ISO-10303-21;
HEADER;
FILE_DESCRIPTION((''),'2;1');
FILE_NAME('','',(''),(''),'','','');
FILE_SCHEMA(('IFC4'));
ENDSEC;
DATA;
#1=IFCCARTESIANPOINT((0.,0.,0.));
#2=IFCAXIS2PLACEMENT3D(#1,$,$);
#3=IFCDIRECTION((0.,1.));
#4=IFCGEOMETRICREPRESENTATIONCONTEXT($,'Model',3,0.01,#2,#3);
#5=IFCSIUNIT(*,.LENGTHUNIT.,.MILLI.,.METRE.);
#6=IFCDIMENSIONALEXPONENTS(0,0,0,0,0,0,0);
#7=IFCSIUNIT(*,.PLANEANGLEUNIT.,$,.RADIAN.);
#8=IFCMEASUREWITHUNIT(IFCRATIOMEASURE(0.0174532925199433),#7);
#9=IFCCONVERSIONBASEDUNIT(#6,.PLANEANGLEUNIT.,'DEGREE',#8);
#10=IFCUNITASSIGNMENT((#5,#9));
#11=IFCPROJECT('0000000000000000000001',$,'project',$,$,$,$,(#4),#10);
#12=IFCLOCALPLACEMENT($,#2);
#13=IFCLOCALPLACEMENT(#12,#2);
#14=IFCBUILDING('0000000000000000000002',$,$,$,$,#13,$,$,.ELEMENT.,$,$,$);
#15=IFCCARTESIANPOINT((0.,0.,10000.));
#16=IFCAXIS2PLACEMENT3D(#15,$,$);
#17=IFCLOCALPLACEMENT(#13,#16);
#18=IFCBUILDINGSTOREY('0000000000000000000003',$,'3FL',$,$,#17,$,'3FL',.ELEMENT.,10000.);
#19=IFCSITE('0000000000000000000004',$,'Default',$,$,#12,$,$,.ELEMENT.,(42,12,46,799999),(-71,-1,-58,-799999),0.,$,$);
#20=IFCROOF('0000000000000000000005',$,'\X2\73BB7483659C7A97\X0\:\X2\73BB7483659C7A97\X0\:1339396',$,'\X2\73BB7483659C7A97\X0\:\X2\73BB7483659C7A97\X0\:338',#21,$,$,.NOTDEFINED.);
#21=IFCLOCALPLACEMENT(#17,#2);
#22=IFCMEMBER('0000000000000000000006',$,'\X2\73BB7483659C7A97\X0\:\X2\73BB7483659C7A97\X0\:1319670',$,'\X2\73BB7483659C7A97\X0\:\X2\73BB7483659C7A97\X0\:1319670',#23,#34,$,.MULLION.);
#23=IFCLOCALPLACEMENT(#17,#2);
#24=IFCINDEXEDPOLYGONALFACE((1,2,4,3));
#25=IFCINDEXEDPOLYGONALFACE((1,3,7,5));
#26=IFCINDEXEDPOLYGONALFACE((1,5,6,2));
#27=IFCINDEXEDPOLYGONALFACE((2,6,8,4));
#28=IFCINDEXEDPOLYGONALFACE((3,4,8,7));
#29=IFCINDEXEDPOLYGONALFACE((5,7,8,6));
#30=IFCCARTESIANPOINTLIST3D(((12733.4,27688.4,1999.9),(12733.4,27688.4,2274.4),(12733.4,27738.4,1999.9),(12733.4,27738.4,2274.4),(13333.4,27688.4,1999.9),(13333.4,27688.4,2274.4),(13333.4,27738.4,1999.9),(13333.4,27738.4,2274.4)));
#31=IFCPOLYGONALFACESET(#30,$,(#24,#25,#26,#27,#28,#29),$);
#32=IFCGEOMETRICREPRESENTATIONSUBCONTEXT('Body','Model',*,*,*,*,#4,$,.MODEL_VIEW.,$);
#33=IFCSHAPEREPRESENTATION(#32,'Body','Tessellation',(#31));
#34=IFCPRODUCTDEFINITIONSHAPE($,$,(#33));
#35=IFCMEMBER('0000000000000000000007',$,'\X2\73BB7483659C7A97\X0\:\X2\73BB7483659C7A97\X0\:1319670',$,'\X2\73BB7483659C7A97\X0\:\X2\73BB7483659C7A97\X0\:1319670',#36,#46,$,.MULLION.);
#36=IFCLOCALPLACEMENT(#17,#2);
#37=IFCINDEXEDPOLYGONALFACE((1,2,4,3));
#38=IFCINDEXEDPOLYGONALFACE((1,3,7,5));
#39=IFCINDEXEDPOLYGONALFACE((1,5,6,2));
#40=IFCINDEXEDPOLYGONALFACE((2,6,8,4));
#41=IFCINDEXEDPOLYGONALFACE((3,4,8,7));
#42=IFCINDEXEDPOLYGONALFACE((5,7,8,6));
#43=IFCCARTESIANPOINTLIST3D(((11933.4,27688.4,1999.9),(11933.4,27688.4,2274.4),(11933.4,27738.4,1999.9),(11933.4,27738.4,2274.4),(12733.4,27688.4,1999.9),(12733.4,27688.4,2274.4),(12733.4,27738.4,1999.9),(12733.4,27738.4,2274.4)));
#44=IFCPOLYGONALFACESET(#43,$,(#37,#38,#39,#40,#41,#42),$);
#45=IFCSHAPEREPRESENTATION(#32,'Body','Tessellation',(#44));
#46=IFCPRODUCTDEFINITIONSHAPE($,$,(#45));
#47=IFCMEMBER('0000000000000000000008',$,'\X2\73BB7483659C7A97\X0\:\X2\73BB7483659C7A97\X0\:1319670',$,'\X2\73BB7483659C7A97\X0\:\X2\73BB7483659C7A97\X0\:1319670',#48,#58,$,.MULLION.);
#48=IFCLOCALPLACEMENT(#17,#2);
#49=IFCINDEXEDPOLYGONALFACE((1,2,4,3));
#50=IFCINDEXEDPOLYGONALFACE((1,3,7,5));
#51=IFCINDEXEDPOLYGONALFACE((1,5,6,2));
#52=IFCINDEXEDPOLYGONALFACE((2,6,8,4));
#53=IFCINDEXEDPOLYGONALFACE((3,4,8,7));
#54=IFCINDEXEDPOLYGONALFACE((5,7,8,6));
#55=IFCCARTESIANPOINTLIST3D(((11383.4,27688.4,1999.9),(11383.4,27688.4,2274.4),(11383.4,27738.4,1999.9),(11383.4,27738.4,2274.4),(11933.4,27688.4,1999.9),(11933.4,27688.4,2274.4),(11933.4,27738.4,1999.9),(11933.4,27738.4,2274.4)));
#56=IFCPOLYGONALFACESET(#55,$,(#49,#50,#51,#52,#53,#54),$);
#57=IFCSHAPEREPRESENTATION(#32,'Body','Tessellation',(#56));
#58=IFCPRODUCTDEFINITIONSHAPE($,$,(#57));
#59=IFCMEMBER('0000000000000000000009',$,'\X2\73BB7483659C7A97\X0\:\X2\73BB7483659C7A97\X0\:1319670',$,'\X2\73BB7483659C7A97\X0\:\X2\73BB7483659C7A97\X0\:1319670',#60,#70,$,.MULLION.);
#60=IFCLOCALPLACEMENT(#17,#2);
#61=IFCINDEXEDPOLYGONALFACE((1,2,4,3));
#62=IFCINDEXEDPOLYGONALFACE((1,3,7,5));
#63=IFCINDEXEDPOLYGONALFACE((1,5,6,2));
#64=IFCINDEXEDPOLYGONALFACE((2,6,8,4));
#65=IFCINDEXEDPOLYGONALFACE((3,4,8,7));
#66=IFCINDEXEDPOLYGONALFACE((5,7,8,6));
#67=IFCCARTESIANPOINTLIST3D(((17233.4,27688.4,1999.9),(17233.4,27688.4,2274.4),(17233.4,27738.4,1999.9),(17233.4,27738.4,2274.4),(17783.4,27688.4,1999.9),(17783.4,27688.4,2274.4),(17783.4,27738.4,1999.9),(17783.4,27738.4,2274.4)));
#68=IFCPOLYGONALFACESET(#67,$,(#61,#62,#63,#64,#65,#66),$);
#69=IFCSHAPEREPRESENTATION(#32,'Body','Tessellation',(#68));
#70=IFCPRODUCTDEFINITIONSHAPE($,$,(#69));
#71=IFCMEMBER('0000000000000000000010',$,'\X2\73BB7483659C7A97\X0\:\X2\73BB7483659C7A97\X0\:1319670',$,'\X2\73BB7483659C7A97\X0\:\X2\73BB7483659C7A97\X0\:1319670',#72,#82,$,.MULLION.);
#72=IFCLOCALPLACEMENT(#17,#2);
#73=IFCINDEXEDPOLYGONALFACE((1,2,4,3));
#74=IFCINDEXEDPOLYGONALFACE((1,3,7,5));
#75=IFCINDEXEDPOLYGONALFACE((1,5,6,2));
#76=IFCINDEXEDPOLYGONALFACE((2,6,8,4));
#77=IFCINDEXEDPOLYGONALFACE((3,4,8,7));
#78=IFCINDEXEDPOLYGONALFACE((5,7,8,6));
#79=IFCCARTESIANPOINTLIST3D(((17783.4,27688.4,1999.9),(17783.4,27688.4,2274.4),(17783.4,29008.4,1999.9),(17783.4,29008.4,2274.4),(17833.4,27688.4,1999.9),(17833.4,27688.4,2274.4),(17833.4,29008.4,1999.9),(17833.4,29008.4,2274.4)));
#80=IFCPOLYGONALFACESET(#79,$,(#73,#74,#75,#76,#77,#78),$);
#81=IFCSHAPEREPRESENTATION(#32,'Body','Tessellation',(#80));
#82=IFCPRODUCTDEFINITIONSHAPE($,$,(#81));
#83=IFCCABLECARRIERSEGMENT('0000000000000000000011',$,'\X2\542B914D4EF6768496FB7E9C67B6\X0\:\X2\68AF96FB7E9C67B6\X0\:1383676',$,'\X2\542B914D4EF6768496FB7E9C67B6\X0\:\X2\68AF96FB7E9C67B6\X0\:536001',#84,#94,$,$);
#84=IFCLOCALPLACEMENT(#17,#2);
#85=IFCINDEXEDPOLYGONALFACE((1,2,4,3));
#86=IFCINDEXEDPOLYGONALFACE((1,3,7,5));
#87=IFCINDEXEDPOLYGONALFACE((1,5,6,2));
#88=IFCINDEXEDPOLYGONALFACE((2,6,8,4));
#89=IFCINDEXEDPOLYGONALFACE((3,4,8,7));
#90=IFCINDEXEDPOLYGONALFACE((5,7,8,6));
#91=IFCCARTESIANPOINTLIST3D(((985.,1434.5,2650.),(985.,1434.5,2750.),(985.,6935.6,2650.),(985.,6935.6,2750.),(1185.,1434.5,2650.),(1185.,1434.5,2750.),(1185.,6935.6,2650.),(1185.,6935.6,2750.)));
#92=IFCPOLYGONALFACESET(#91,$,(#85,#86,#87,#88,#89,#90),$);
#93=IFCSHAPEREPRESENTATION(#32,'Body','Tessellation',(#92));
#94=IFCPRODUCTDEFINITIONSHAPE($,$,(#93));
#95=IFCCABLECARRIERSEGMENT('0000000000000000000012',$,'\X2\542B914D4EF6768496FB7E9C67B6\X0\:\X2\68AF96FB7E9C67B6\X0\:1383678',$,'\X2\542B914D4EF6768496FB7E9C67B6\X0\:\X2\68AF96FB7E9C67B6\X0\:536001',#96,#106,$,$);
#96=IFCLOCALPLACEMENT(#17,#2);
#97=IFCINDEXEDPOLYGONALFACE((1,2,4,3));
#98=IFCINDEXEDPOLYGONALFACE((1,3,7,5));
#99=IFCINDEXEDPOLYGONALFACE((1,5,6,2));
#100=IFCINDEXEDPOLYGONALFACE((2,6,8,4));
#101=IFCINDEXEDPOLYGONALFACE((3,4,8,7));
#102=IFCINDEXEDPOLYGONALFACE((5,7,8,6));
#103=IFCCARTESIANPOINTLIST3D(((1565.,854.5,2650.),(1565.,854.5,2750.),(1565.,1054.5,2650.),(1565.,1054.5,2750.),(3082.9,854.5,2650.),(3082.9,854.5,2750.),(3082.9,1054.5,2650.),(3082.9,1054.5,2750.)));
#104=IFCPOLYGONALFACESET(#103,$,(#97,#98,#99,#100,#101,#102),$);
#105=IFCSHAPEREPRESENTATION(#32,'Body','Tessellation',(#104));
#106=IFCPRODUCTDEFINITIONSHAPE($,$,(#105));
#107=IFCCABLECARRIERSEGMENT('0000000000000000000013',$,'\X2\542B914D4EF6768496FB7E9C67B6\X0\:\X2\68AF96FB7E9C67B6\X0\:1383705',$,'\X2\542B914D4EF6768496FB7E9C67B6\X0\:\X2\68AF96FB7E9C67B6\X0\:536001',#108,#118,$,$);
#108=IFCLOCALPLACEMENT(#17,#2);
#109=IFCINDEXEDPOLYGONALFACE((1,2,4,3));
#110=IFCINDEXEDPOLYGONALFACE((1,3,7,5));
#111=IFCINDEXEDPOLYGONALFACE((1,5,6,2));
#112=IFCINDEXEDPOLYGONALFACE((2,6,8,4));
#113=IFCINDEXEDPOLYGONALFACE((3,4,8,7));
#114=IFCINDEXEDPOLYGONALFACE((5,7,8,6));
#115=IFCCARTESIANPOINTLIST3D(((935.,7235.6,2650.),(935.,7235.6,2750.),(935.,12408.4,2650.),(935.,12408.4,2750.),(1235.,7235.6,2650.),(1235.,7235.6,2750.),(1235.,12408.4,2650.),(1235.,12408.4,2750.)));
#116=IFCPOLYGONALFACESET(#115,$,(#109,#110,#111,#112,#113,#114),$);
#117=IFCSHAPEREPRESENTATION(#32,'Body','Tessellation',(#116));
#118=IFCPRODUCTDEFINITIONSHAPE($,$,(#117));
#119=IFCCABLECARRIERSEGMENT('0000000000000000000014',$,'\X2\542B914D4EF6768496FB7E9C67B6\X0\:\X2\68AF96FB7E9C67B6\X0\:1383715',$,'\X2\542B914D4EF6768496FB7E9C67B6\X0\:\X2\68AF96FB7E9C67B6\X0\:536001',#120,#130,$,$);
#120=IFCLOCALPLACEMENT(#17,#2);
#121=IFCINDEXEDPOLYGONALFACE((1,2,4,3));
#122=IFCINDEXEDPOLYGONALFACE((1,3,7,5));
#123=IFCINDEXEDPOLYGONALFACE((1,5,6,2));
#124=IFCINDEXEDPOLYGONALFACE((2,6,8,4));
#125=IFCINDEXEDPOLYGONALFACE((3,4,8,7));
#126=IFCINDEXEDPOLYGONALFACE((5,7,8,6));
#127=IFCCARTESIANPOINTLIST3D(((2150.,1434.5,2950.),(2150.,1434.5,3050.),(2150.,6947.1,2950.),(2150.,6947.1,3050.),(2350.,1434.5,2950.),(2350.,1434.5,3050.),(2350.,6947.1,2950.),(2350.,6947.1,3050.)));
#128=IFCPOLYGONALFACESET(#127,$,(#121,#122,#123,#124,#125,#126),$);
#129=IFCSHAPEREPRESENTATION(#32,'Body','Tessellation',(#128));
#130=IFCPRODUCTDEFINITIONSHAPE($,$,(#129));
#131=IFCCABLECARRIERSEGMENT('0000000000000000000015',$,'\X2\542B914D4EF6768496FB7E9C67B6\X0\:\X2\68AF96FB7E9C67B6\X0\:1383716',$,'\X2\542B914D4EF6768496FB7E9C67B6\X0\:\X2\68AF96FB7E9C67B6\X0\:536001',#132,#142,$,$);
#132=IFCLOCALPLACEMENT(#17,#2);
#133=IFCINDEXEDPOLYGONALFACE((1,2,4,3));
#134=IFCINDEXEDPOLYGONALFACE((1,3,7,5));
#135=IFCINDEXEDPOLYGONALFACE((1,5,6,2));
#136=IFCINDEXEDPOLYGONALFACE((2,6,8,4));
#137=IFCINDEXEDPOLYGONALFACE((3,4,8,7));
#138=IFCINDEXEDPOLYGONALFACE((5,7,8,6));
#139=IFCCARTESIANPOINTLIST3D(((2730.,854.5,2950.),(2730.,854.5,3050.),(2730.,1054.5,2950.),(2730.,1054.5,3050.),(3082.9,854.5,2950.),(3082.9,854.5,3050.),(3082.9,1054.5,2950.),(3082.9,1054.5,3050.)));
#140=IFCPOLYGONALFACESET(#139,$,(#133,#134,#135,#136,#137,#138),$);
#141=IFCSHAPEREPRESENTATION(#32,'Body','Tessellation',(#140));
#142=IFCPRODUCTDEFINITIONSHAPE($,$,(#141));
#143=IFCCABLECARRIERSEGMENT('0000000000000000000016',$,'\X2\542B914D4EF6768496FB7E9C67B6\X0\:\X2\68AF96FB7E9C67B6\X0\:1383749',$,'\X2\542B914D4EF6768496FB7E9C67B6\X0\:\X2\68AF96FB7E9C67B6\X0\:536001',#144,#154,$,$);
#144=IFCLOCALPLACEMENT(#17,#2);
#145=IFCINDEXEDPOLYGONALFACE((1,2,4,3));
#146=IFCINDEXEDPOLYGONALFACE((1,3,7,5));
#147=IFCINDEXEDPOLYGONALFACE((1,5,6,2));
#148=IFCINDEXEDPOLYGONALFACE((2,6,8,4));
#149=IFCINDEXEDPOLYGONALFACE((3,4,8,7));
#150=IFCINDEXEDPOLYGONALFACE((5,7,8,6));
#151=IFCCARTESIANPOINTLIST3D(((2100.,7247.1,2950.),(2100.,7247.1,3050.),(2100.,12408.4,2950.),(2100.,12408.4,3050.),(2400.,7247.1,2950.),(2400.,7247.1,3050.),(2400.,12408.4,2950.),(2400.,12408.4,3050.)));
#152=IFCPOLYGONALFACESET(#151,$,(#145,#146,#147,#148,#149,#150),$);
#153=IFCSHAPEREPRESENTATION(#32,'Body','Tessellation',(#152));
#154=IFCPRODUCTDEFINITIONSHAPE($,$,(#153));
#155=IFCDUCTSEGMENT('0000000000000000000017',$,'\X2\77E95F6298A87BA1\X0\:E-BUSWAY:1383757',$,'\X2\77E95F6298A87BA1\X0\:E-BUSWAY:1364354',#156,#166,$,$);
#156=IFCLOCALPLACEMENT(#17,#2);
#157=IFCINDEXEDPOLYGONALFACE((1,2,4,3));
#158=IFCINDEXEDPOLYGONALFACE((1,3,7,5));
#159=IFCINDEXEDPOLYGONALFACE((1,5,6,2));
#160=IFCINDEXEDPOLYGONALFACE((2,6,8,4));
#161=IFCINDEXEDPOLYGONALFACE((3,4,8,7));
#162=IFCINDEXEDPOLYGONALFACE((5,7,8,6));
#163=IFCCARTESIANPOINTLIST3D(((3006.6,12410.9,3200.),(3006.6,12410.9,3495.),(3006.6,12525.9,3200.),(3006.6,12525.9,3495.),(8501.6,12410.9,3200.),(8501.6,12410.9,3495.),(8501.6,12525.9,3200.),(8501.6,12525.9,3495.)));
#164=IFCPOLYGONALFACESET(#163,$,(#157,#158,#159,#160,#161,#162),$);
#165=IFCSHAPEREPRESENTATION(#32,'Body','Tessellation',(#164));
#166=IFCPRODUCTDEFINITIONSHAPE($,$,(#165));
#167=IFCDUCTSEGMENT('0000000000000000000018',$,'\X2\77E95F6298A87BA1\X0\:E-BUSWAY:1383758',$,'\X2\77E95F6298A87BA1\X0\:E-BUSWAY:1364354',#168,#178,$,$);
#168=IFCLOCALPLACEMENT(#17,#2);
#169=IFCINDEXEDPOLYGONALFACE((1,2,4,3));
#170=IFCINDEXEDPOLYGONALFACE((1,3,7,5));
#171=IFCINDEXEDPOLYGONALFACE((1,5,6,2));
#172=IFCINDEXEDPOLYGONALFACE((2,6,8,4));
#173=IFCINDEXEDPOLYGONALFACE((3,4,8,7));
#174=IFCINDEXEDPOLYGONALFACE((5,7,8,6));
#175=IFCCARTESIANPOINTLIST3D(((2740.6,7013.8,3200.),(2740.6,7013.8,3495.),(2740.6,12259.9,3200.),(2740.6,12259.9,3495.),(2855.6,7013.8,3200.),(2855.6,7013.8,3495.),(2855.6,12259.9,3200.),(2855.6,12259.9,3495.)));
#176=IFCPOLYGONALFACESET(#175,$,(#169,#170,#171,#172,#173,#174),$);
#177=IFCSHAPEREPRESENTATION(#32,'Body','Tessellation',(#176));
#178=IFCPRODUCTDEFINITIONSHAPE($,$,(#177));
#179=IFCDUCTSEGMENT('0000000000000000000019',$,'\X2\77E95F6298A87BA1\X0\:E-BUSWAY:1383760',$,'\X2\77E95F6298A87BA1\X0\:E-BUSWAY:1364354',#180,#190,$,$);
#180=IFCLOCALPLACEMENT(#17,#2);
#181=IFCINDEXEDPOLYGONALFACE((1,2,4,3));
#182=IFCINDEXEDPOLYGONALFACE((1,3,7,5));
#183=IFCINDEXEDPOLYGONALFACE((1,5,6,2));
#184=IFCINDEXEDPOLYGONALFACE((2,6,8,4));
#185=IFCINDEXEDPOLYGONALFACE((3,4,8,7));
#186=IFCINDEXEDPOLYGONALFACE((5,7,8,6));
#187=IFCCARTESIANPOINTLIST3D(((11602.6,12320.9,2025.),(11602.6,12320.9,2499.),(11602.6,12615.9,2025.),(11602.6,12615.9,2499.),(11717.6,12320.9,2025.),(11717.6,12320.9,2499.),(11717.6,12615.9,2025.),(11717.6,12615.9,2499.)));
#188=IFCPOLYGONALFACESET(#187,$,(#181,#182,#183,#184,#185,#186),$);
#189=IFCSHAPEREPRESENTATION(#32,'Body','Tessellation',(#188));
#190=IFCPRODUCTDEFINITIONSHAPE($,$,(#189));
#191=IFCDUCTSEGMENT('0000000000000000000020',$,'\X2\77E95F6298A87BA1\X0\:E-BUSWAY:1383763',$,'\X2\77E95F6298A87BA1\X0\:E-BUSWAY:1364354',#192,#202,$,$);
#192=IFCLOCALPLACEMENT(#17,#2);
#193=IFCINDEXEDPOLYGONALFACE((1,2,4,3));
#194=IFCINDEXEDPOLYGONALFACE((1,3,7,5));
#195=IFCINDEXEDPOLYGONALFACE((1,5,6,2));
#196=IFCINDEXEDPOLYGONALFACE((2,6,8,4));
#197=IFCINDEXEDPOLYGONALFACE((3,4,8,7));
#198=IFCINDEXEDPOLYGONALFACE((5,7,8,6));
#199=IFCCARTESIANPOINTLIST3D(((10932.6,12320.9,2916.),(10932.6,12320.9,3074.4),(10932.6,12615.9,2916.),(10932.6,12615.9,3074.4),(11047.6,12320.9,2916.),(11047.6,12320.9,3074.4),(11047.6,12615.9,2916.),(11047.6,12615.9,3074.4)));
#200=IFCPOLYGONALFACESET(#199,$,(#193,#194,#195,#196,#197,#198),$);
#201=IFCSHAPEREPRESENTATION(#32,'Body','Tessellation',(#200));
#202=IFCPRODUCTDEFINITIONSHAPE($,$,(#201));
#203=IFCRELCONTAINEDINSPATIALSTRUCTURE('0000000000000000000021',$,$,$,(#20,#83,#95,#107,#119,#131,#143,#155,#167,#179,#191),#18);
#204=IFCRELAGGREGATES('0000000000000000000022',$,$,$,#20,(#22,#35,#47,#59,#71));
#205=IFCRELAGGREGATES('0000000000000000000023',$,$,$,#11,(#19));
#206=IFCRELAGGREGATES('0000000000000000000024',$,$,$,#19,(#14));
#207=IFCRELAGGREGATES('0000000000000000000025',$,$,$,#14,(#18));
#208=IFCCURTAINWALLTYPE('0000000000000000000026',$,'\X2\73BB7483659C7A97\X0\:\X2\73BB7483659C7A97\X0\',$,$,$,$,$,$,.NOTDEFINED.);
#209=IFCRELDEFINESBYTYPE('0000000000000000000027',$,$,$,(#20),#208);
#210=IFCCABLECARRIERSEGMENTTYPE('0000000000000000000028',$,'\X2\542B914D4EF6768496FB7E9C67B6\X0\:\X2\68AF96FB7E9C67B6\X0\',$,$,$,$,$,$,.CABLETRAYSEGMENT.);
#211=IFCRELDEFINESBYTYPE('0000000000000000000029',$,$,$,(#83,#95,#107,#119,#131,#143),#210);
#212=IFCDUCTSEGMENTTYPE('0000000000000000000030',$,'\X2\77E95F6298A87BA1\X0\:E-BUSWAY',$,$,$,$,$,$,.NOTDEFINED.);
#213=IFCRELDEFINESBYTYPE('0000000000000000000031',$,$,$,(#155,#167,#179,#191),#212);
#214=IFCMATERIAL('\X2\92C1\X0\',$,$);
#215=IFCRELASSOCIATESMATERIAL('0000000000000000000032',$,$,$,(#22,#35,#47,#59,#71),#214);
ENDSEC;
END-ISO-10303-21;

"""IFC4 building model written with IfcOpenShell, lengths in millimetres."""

from ifc_helpers import new_model, entity, si_unit, converted_unit, direction, frame, frame_2d, origin, origin_2d_with_axis, place, context, subcontext, project, spatial, rectangle, extrude, material, type_object, element, aggregate, save


model = new_model("IFC4")

# Units and contexts
model_context = context("Model", 3, precision=0.01, world=origin(), true_north=direction((0.0, 1.0)))
body_context = subcontext(model_context, "Body", "Model", "MODEL_VIEW")
ifc_project = project(units=[si_unit("LENGTHUNIT", "METRE", prefix="MILLI"), converted_unit("PLANEANGLEUNIT", "DEGREE", entity("IfcRatioMeasure", 0.0174532925199433), si_unit("PLANEANGLEUNIT", "RADIAN"), dimensions=[0, 0, 0, 0, 0, 0, 0])], contexts=[model_context])

# Site, building, storey
site_placement = place(None, origin())
site = spatial("IfcSite", under=ifc_project, at=site_placement, Name="Default", CompositionType="ELEMENT", RefLatitude=(42, 12, 46, 799999), RefLongitude=(-71, -1, -58, -799999), RefElevation=0.0)
building_placement = place(site_placement, origin())
building = spatial("IfcBuilding", under=site, at=building_placement, CompositionType="ELEMENT")
storey_placement = place(building_placement, frame((0.0, 0.0, 10000.0)))
storey = spatial("IfcBuildingStorey", under=building, at=storey_placement, Name="3FL", LongName="3FL", CompositionType="ELEMENT", Elevation=10000.0)

# Roof, members
curtain_wall_type = type_object("IfcCurtainWallType", Name="玻璃斜窗:玻璃斜窗", PredefinedType="NOTDEFINED")
roof_placement = place(storey_placement, frame((0.0, 0.0, -10000.0)))
roof = element("IfcRoof", 1, at=roof_placement, inside=storey, type_object=curtain_wall_type, Name="玻璃斜窗:玻璃斜窗:1339396", ObjectType="玻璃斜窗:玻璃斜窗:338", PredefinedType="NOTDEFINED")
ifc_material = material(Name="鋁")
member_1_placement = place(roof_placement, frame((0.0, 0.0, 10000.0)))
member_1 = element("IfcMember", 2, at=member_1_placement, material=ifc_material, Name="玻璃斜窗:玻璃斜窗:1319670", ObjectType="玻璃斜窗:玻璃斜窗:1319670", PredefinedType="MULLION", context=body_context, shape_type="SweptSolid", body=[
    extrude(rectangle(XDim=274.5, YDim=50.0, at=frame_2d((0.0, 0.0), x_axis=(1.0, 0.0))), frame((13333.4, 27713.4, 2137.2), z_axis=(-1.0, 0.0, 0.0), x_axis=(0.0, 0.0, -1.0)), (0.0, 0.0, 1.0), 600.0),
])
member_2_placement = place(roof_placement, frame((0.0, 0.0, 10000.0)))
member_2 = element("IfcMember", 3, at=member_2_placement, material=ifc_material, Name="玻璃斜窗:玻璃斜窗:1319670", ObjectType="玻璃斜窗:玻璃斜窗:1319670", PredefinedType="MULLION", context=body_context, shape_type="SweptSolid", body=[
    extrude(rectangle(XDim=274.5, YDim=50.0, at=frame_2d((0.0, 0.0), x_axis=(1.0, 0.0))), frame((12733.4, 27713.4, 2137.2), z_axis=(-1.0, 0.0, 0.0), x_axis=(0.0, 0.0, -1.0)), (0.0, 0.0, 1.0), 800.0),
])
member_3_placement = place(roof_placement, frame((0.0, 0.0, 10000.0)))
member_3 = element("IfcMember", 4, at=member_3_placement, material=ifc_material, Name="玻璃斜窗:玻璃斜窗:1319670", ObjectType="玻璃斜窗:玻璃斜窗:1319670", PredefinedType="MULLION", context=body_context, shape_type="SweptSolid", body=[
    extrude(rectangle(XDim=274.5, YDim=50.0, at=frame_2d((0.0, 0.0), x_axis=(1.0, 0.0))), frame((11933.4, 27713.4, 2137.2), z_axis=(-1.0, 0.0, 0.0), x_axis=(0.0, 0.0, -1.0)), (0.0, 0.0, 1.0), 550.0),
])
member_4_placement = place(roof_placement, frame((0.0, 0.0, 10000.0)))
member_4 = element("IfcMember", 5, at=member_4_placement, material=ifc_material, Name="玻璃斜窗:玻璃斜窗:1319670", ObjectType="玻璃斜窗:玻璃斜窗:1319670", PredefinedType="MULLION", context=body_context, shape_type="SweptSolid", body=[
    extrude(rectangle(XDim=274.5, YDim=50.0, at=frame_2d((0.0, 0.0), x_axis=(1.0, 0.0))), frame((17783.4, 27713.4, 2137.2), z_axis=(-1.0, 0.0, 0.0), x_axis=(0.0, 0.0, -1.0)), (0.0, 0.0, 1.0), 550.0),
])
member_5_placement = place(roof_placement, frame((0.0, 0.0, 10000.0)))
member_5 = element("IfcMember", 6, at=member_5_placement, material=ifc_material, Name="玻璃斜窗:玻璃斜窗:1319670", ObjectType="玻璃斜窗:玻璃斜窗:1319670", PredefinedType="MULLION", context=body_context, shape_type="SweptSolid", body=[
    extrude(rectangle(XDim=274.5, YDim=50.0, at=frame_2d((0.0, 0.0), x_axis=(1.0, 0.0))), frame((17808.4, 29008.4, 2137.2), z_axis=(0.0, -1.0, 0.0), x_axis=(0.0, 0.0, -1.0)), (0.0, 0.0, 1.0), 1320.0),
])
aggregate(roof, [member_1, member_2, member_3, member_4, member_5])

# Cable carrier segments
cable_carrier_segment_type = type_object("IfcCableCarrierSegmentType", Name="含配件的電纜架:梯電纜架", PredefinedType="CABLETRAYSEGMENT")
cable_carrier_segment_1_placement = place(storey_placement, frame((985.0, 1434.5, 2650.0)))
element("IfcCableCarrierSegment", 7, at=cable_carrier_segment_1_placement, inside=storey, type_object=cable_carrier_segment_type, Name="含配件的電纜架:梯電纜架:1383676", ObjectType="含配件的電纜架:梯電纜架:536001", context=body_context, shape_type="SweptSolid", body=[
    extrude(rectangle(XDim=5501.1, YDim=200.0, at=origin_2d_with_axis()), frame((100.0, 2750.5, 0.0), z_axis=(0.0, 0.0, 1.0), x_axis=(0.0, -1.0, 0.0)), (0.0, 0.0, 1.0), 100.0),
])
cable_carrier_segment_2_placement = place(storey_placement, frame((1565.0, 854.5, 2650.0)))
element("IfcCableCarrierSegment", 8, at=cable_carrier_segment_2_placement, inside=storey, type_object=cable_carrier_segment_type, Name="含配件的電纜架:梯電纜架:1383678", ObjectType="含配件的電纜架:梯電纜架:536001", context=body_context, shape_type="SweptSolid", body=[
    extrude(rectangle(XDim=1517.9, YDim=200.0, at=frame_2d((0.0, 0.0), x_axis=(1.0, 0.0))), frame((759.0, 100.0, 0.0)), (0.0, 0.0, 1.0), 100.0),
])
cable_carrier_segment_3_placement = place(storey_placement, frame((935.0, 7235.6, 2650.0)))
element("IfcCableCarrierSegment", 9, at=cable_carrier_segment_3_placement, inside=storey, type_object=cable_carrier_segment_type, Name="含配件的電纜架:梯電纜架:1383705", ObjectType="含配件的電纜架:梯電纜架:536001", context=body_context, shape_type="SweptSolid", body=[
    extrude(rectangle(XDim=5172.8, YDim=300.0, at=frame_2d((0.0, 0.0), x_axis=(1.0, 0.0))), frame((150.0, 2586.4, 0.0), z_axis=(0.0, 0.0, 1.0), x_axis=(0.0, -1.0, 0.0)), (0.0, 0.0, 1.0), 100.0),
])
cable_carrier_segment_4_placement = place(storey_placement, frame((2150.0, 1434.5, 2950.0)))
element("IfcCableCarrierSegment", 10, at=cable_carrier_segment_4_placement, inside=storey, type_object=cable_carrier_segment_type, Name="含配件的電纜架:梯電纜架:1383715", ObjectType="含配件的電纜架:梯電纜架:536001", context=body_context, shape_type="SweptSolid", body=[
    extrude(rectangle(XDim=5512.6, YDim=200.0, at=frame_2d((0.0, 0.0), x_axis=(1.0, 0.0))), frame((100.0, 2756.3, 0.0), z_axis=(0.0, 0.0, 1.0), x_axis=(0.0, -1.0, 0.0)), (0.0, 0.0, 1.0), 100.0),
])
cable_carrier_segment_5_placement = place(storey_placement, frame((2730.0, 854.5, 2950.0)))
element("IfcCableCarrierSegment", 11, at=cable_carrier_segment_5_placement, inside=storey, type_object=cable_carrier_segment_type, Name="含配件的電纜架:梯電纜架:1383716", ObjectType="含配件的電纜架:梯電纜架:536001", context=body_context, shape_type="SweptSolid", body=[
    extrude(rectangle(XDim=352.9, YDim=200.0, at=origin_2d_with_axis()), frame((176.5, 100.0, 0.0)), (0.0, 0.0, 1.0), 100.0),
])
cable_carrier_segment_6_placement = place(storey_placement, frame((2100.0, 7247.1, 2950.0)))
element("IfcCableCarrierSegment", 12, at=cable_carrier_segment_6_placement, inside=storey, type_object=cable_carrier_segment_type, Name="含配件的電纜架:梯電纜架:1383749", ObjectType="含配件的電纜架:梯電纜架:536001", context=body_context, shape_type="SweptSolid", body=[
    extrude(rectangle(XDim=5161.2, YDim=300.0, at=frame_2d((0.0, 0.0), x_axis=(1.0, 0.0))), frame((150.0, 2580.6, 0.0), z_axis=(0.0, 0.0, 1.0), x_axis=(0.0, -1.0, 0.0)), (0.0, 0.0, 1.0), 100.0),
])

# Duct segments
duct_segment_type = type_object("IfcDuctSegmentType", Name="矩形風管:E-BUSWAY", PredefinedType="NOTDEFINED")
duct_segment_1_placement = place(storey_placement, frame((3006.6, 12410.9, 3200.0)))
element("IfcDuctSegment", 13, at=duct_segment_1_placement, inside=storey, type_object=duct_segment_type, Name="矩形風管:E-BUSWAY:1383757", ObjectType="矩形風管:E-BUSWAY:1364354", context=body_context, shape_type="SweptSolid", body=[
    extrude(rectangle(XDim=5495.0, YDim=115.0, at=origin_2d_with_axis()), frame((2747.5, 57.5, 0.0), z_axis=(0.0, 0.0, 1.0), x_axis=(-1.0, 0.0, 0.0)), (0.0, 0.0, 1.0), 295.0),
])
duct_segment_2_placement = place(storey_placement, frame((2740.6, 7013.8, 3200.0)))
element("IfcDuctSegment", 14, at=duct_segment_2_placement, inside=storey, type_object=duct_segment_type, Name="矩形風管:E-BUSWAY:1383758", ObjectType="矩形風管:E-BUSWAY:1364354", context=body_context, shape_type="SweptSolid", body=[
    extrude(rectangle(XDim=5246.1, YDim=115.0, at=frame_2d((0.0, 0.0), x_axis=(1.0, 0.0))), frame((57.5, 2623.1, 0.0), z_axis=(0.0, 0.0, 1.0), x_axis=(0.0, -1.0, 0.0)), (0.0, 0.0, 1.0), 295.0),
])
duct_segment_3_placement = place(storey_placement, frame((11602.6, 12320.9, 2025.0)))
element("IfcDuctSegment", 15, at=duct_segment_3_placement, inside=storey, type_object=duct_segment_type, Name="矩形風管:E-BUSWAY:1383760", ObjectType="矩形風管:E-BUSWAY:1364354", context=body_context, shape_type="SweptSolid", body=[
    extrude(rectangle(XDim=115.0, YDim=295.0, at=origin_2d_with_axis()), frame((57.5, 147.5, 0.0), z_axis=(0.0, 0.0, 1.0), x_axis=(-1.0, 0.0, 0.0)), (0.0, 0.0, 1.0), 474.0),
])
duct_segment_4_placement = place(storey_placement, frame((10932.6, 12320.9, 2916.0)))
element("IfcDuctSegment", 16, at=duct_segment_4_placement, inside=storey, type_object=duct_segment_type, Name="矩形風管:E-BUSWAY:1383763", ObjectType="矩形風管:E-BUSWAY:1364354", context=body_context, shape_type="SweptSolid", body=[
    extrude(rectangle(XDim=115.0, YDim=295.0, at=frame_2d((0.0, 0.0), x_axis=(1.0, 0.0))), frame((57.5, 147.5, 0.0), z_axis=(0.0, 0.0, 1.0), x_axis=(-1.0, 0.0, 0.0)), (0.0, 0.0, 1.0), 158.4),
])

save(model, "model.ifc")
